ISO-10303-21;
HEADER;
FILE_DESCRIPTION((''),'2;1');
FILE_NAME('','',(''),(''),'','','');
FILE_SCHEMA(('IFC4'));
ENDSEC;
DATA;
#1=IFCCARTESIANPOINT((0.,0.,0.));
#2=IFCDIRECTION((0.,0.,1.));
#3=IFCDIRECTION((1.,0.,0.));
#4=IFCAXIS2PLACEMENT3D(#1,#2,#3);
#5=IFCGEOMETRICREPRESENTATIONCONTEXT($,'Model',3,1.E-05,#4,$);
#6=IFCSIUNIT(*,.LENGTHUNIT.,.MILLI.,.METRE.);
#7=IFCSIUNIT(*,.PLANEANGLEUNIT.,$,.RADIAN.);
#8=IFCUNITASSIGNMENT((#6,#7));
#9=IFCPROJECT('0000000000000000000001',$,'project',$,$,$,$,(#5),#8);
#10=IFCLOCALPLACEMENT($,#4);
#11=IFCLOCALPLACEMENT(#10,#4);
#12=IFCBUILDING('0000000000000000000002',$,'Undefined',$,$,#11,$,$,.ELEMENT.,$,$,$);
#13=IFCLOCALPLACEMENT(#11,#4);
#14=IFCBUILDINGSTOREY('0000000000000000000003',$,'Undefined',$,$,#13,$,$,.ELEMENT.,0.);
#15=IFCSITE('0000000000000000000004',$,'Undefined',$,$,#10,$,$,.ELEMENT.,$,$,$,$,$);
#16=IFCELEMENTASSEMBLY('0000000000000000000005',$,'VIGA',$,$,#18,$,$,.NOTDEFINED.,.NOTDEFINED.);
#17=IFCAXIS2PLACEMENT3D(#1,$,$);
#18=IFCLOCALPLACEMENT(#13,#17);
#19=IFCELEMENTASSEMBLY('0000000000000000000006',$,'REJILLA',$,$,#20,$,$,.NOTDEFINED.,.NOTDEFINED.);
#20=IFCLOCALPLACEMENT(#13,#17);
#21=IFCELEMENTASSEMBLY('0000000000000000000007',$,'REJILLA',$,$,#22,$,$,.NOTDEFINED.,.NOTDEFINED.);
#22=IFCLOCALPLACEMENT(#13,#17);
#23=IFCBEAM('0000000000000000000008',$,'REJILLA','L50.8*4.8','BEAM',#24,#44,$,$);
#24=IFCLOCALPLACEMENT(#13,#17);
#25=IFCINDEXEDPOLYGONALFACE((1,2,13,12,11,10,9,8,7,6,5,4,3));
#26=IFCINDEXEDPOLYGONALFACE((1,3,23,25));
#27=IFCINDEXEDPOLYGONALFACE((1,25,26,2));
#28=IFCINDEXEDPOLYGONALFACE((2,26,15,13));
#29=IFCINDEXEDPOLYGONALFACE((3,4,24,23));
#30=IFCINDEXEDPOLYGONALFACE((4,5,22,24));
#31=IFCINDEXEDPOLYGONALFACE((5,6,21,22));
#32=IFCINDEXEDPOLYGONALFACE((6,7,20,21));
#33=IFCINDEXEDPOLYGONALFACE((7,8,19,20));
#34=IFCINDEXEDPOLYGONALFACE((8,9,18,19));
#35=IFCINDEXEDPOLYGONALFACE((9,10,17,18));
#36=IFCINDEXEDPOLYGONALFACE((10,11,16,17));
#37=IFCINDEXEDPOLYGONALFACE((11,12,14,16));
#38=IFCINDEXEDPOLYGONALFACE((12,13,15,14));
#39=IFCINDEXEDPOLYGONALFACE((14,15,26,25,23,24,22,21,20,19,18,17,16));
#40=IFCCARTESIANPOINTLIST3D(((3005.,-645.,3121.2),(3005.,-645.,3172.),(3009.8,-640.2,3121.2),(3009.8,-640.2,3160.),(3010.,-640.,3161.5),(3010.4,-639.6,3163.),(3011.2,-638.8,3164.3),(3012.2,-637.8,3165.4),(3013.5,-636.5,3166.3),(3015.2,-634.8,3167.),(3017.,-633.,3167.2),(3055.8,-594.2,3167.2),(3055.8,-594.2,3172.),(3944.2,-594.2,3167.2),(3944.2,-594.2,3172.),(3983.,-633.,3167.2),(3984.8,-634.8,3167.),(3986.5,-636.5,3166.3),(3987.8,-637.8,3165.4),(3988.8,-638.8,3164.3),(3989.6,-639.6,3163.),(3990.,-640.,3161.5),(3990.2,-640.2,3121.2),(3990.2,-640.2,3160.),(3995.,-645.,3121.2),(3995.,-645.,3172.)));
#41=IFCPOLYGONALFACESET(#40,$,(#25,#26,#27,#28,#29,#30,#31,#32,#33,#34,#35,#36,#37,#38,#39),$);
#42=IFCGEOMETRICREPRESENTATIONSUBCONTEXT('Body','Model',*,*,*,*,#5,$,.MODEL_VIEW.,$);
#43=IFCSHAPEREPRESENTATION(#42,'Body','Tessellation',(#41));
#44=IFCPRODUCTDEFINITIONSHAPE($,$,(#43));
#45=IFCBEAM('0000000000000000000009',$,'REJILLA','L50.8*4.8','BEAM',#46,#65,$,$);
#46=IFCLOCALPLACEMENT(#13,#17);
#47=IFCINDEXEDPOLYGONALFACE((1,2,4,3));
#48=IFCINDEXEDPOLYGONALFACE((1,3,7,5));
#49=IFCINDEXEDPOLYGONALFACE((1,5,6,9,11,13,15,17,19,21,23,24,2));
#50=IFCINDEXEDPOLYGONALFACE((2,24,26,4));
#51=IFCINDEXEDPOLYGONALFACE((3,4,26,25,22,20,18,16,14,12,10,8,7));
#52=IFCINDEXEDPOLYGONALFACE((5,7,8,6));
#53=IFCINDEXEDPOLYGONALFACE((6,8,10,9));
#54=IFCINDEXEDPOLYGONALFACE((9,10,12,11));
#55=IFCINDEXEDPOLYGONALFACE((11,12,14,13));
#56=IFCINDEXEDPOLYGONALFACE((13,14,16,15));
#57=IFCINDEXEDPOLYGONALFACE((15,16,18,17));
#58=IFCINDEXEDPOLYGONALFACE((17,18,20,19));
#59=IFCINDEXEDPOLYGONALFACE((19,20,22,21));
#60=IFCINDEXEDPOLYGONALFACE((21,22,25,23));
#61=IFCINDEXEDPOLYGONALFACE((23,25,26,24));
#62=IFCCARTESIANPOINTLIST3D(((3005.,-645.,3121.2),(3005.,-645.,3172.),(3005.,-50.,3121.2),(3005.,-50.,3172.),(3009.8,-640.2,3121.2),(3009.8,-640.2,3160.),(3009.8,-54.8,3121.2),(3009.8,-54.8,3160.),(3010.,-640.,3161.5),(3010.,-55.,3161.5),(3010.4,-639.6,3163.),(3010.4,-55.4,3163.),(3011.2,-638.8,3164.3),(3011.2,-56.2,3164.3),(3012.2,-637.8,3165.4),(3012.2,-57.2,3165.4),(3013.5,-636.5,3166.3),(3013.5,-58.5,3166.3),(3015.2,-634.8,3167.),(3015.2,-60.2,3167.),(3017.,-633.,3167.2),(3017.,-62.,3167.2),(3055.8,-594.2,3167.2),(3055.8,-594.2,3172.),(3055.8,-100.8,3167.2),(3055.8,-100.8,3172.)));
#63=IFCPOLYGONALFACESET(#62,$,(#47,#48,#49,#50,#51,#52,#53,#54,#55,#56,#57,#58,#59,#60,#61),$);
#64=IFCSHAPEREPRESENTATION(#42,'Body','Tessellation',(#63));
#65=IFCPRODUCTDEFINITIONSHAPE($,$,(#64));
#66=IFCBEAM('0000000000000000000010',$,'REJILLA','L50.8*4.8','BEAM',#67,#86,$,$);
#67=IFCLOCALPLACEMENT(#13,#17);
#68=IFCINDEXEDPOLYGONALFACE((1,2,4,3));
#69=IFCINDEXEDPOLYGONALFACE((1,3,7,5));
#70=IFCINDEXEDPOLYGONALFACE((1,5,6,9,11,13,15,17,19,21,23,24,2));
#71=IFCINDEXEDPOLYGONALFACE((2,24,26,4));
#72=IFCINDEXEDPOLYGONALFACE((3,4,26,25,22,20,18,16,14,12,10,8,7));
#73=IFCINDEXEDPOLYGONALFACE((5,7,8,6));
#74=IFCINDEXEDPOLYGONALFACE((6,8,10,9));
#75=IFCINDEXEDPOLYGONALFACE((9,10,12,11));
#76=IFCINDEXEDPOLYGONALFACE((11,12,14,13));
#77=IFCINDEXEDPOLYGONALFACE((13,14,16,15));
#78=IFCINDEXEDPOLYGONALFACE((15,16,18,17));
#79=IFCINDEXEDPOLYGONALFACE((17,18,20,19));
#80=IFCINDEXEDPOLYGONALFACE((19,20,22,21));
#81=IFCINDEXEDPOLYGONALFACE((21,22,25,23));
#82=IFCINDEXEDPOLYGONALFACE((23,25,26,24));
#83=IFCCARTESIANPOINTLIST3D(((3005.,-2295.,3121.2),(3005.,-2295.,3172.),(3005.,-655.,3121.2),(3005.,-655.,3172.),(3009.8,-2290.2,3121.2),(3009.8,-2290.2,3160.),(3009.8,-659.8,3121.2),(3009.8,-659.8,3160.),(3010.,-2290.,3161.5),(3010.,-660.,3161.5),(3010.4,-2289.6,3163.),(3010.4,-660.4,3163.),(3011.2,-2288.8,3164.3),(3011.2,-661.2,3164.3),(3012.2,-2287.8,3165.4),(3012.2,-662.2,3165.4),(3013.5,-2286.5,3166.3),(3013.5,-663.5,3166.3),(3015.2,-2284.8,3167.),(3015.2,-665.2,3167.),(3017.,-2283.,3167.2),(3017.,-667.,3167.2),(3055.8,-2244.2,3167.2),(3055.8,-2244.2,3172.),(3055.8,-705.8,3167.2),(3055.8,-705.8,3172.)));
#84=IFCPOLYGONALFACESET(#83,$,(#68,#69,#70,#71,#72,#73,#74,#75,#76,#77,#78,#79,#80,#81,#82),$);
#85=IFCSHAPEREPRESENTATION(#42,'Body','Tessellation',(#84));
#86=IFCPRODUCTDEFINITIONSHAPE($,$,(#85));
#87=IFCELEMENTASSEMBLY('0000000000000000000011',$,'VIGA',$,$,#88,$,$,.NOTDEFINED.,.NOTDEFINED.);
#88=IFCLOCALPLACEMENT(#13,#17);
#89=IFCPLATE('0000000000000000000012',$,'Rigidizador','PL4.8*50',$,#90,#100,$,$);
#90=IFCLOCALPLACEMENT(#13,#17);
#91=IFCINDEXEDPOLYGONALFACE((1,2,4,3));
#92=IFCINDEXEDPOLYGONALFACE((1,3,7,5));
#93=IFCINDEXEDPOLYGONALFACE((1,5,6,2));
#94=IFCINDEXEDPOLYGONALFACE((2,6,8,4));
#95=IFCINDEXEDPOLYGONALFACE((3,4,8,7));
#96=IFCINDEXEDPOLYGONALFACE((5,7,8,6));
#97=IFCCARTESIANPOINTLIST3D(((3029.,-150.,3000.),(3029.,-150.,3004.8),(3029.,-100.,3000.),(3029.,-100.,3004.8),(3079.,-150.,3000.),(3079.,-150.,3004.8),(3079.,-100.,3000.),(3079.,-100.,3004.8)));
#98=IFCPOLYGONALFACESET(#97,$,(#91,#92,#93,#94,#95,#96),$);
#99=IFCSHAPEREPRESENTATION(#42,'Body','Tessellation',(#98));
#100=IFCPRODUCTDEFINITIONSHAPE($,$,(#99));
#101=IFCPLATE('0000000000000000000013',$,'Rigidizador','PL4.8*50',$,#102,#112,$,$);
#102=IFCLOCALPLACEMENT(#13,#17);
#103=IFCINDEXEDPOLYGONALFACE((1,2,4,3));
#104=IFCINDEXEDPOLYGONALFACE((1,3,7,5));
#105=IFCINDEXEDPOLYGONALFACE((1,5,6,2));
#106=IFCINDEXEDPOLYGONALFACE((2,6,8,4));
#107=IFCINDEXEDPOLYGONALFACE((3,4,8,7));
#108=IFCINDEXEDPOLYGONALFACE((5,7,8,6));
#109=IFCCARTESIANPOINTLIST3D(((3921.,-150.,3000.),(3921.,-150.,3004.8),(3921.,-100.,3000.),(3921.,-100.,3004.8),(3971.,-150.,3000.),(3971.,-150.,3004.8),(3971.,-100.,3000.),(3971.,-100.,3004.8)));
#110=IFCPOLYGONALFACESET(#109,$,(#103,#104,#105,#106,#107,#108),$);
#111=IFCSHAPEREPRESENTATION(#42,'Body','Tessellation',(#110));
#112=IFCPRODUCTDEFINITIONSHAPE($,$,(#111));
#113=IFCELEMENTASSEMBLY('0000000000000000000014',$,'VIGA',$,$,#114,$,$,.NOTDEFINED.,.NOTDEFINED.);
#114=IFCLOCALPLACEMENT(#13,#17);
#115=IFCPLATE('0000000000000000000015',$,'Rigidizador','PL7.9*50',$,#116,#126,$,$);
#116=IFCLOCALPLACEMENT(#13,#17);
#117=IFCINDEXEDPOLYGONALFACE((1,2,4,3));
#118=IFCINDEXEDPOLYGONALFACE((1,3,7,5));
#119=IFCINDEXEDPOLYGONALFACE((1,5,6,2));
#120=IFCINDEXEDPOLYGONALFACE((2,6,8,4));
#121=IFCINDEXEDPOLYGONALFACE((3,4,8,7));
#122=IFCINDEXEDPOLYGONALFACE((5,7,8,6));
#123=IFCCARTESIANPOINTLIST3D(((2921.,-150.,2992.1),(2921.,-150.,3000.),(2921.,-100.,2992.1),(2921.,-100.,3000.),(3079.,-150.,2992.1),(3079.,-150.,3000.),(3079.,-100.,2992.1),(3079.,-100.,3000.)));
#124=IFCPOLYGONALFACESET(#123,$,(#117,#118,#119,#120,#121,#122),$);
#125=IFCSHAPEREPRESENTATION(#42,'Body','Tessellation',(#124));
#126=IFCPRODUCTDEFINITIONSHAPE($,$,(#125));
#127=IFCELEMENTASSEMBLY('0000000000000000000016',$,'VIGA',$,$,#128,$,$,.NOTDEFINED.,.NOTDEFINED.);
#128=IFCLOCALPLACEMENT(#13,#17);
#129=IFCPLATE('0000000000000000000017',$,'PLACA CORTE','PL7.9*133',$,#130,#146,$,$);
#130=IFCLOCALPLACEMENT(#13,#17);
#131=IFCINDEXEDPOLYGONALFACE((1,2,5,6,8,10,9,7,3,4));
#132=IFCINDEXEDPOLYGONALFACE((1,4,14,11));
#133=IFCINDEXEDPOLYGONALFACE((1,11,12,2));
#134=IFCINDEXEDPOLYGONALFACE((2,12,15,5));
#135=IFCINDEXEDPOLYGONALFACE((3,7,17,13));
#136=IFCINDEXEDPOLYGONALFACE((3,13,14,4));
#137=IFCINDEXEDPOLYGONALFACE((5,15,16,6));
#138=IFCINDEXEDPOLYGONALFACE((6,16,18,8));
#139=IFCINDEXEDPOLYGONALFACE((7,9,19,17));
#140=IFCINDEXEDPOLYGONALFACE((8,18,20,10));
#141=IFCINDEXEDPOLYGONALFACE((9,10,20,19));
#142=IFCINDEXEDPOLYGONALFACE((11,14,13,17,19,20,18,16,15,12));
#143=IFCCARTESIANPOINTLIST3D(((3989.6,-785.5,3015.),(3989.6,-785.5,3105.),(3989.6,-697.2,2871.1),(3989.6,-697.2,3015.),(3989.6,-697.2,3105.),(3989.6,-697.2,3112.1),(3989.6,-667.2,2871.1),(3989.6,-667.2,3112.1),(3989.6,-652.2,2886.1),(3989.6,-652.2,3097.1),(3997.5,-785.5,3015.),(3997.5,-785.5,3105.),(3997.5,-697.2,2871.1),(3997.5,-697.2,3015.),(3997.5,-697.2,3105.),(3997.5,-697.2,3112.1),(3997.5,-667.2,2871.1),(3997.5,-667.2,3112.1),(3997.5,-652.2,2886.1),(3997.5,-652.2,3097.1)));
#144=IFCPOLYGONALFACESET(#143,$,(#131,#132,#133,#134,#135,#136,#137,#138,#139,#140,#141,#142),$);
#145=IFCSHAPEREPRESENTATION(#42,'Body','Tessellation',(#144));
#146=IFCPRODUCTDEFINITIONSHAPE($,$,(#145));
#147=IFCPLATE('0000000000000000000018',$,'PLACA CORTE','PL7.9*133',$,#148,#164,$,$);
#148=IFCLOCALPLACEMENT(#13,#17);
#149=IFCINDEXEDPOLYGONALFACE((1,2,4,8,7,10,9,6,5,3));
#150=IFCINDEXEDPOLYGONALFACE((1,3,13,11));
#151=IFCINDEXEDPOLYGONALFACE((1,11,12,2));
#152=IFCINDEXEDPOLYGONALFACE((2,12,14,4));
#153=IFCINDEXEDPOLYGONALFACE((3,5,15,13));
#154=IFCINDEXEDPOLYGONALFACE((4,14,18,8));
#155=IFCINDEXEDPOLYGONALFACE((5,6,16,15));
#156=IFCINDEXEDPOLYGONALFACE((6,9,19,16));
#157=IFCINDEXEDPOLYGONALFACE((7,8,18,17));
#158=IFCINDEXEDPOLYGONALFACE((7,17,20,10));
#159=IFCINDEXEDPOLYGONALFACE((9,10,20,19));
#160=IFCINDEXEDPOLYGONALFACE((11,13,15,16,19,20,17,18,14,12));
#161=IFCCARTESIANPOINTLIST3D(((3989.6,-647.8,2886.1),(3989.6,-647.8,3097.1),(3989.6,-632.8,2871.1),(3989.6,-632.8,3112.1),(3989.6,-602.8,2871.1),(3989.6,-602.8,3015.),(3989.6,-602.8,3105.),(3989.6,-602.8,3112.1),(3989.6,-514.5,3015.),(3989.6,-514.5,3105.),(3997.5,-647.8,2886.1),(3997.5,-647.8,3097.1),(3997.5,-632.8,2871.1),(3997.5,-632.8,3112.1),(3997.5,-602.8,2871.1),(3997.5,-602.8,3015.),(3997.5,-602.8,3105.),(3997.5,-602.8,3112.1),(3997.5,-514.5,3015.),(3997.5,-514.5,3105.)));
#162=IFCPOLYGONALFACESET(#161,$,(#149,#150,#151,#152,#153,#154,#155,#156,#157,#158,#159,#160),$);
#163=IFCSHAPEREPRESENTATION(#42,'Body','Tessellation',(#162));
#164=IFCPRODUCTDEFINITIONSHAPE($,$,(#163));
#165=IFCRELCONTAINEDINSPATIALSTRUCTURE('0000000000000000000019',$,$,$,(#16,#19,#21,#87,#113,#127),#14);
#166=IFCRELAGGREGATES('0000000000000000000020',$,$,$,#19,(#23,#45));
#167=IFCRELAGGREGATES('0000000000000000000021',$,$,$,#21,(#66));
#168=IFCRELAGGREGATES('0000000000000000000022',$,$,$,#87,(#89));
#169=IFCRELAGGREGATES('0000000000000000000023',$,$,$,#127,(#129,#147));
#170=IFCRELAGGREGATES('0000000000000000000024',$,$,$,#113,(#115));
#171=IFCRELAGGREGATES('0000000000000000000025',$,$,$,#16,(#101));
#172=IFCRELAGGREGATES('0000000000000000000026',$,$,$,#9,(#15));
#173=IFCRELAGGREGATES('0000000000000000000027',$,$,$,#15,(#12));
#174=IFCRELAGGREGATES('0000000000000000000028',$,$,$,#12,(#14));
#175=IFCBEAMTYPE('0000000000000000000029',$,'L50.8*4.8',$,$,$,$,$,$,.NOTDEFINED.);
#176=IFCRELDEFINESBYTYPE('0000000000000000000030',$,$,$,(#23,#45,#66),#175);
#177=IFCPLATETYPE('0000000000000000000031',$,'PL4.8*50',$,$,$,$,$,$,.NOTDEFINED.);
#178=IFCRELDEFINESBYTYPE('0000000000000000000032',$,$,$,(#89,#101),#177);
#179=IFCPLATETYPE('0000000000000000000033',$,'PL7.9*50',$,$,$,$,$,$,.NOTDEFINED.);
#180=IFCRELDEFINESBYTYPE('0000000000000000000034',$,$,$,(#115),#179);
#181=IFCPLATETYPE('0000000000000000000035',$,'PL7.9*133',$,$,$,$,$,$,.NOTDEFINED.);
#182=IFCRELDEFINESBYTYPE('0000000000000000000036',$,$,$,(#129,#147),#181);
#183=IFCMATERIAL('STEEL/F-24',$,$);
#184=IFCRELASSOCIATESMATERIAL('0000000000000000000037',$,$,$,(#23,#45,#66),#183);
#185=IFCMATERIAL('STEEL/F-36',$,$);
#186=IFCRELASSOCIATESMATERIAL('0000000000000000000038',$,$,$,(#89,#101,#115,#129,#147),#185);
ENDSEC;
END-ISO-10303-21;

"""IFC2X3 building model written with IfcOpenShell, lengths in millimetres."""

from ifc_helpers import new_model, si_unit, frame, origin_with_axes, origin_2d_with_axis, place, context, subcontext, project, spatial, polyline, l_section, outline, extrude, clip, halfspace, material, type_object, element, aggregate, save


model = new_model("IFC2X3")

# Units and contexts
model_context = context("Model", 3, precision=1e-05, world=origin_with_axes())
body_context = subcontext(model_context, "Body", "Model", "MODEL_VIEW")
ifc_project = project(units=[si_unit("LENGTHUNIT", "METRE", prefix="MILLI"), si_unit("PLANEANGLEUNIT", "RADIAN")], contexts=[model_context])

# Site, building, storey
site_placement = place(None, origin_with_axes())
site = spatial("IfcSite", under=ifc_project, at=site_placement, Name="Undefined", CompositionType="ELEMENT")
building_placement = place(site_placement, origin_with_axes())
building = spatial("IfcBuilding", under=site, at=building_placement, Name="Undefined", CompositionType="ELEMENT")
storey_placement = place(building_placement, origin_with_axes())
storey = spatial("IfcBuildingStorey", under=building, at=storey_placement, Name="Undefined", CompositionType="ELEMENT", Elevation=0.0)

# Element assembly
assembly_1_placement = place(storey_placement, origin_with_axes())
assembly_1 = element("IfcElementAssembly", 1, at=assembly_1_placement, inside=storey, Name="VIGA", AssemblyPlace="NOTDEFINED", PredefinedType="NOTDEFINED")
ifc_material_1 = material(Name="STEEL/F-36")

# Element assemblies
assembly_2_placement = place(storey_placement, origin_with_axes())
assembly_2 = element("IfcElementAssembly", 2, at=assembly_2_placement, inside=storey, Name="REJILLA", AssemblyPlace="NOTDEFINED", PredefinedType="NOTDEFINED")
ifc_material_2 = material(Name="STEEL/F-24")
assembly_3_placement = place(storey_placement, origin_with_axes())
assembly_3 = element("IfcElementAssembly", 3, at=assembly_3_placement, inside=storey, Name="REJILLA", AssemblyPlace="NOTDEFINED", PredefinedType="NOTDEFINED")

# Shared definitions
beam_type_1 = type_object("IfcBeamType", Name="L50.8*4.8", PredefinedType="NOTDEFINED")

# Beams
beam_1_placement = place(assembly_2_placement, frame((3005.0, -619.6, 3146.6), z_axis=(0.0, 0.0, -1.0), x_axis=(1.0, 0.0, 0.0)))
beam_1 = element("IfcBeam", 4, at=beam_1_placement, type_object=beam_type_1, material=ifc_material_2, Name="REJILLA", Description="L50.8*4.8", ObjectType="BEAM", context=body_context, shape_type="Clipping", body=[
    clip(clip(extrude(l_section(Depth=50.8, Width=50.8, Thickness=4.8, FilletRadius=7.2, at=origin_2d_with_axis()), frame((1015.9, 0.0, 0.0), z_axis=(-1.0, 0.0, 0.0), x_axis=(0.0, -1.0, 0.0)), (0.0, 0.0, 1.0), 1041.8), halfspace(frame((939.2, -25.4, 0.0), z_axis=(-0.707107, 0.707107, 0.0), x_axis=(0.0, 0.0, -1.0)), True)), halfspace(frame((50.8, -25.4, 0.0), z_axis=(-0.707107, -0.707107, 0.0), x_axis=(0.0, 0.0, -1.0)), False)),
])
beam_2_placement = place(assembly_2_placement, frame((3030.4, 0.0, 3146.6), z_axis=(0.0, 0.0, -1.0), x_axis=(0.0, -1.0, 0.0)))
beam_2 = element("IfcBeam", 5, at=beam_2_placement, type_object=beam_type_1, material=ifc_material_2, Name="REJILLA", Description="L50.8*4.8", ObjectType="BEAM", context=body_context, shape_type="Clipping", body=[
    clip(clip(extrude(l_section(Depth=50.8, Width=50.8, Thickness=4.8, FilletRadius=7.2, at=origin_2d_with_axis()), frame((670.9, 0.0, 0.0), z_axis=(-1.0, 0.0, 0.0), x_axis=(0.0, -1.0, 0.0)), (0.0, 0.0, 1.0), 670.9), halfspace(frame((594.2, -25.4, 0.0), z_axis=(-0.707107, 0.707107, 0.0), x_axis=(0.0, 0.0, -1.0)), True)), halfspace(frame((100.8, -25.4, 0.0), z_axis=(-0.707107, -0.707107, 0.0), x_axis=(0.0, 0.0, -1.0)), False)),
])
beam_3_placement = place(assembly_3_placement, frame((3030.4, -655.0, 3146.6), z_axis=(0.0, 0.0, -1.0), x_axis=(0.0, -1.0, 0.0)))
beam_3 = element("IfcBeam", 6, at=beam_3_placement, type_object=beam_type_1, material=ifc_material_2, Name="REJILLA", Description="L50.8*4.8", ObjectType="BEAM", context=body_context, shape_type="Clipping", body=[
    clip(clip(extrude(l_section(Depth=50.8, Width=50.8, Thickness=4.8, FilletRadius=7.2, at=origin_2d_with_axis()), frame((1665.9, 0.0, 0.0), z_axis=(-1.0, 0.0, 0.0), x_axis=(0.0, -1.0, 0.0)), (0.0, 0.0, 1.0), 1691.8), halfspace(frame((1589.2, -25.4, 0.0), z_axis=(-0.707107, 0.707107, 0.0), x_axis=(0.0, 0.0, -1.0)), True)), halfspace(frame((50.8, -25.4, 0.0), z_axis=(-0.707107, -0.707107, 0.0), x_axis=(0.0, 0.0, -1.0)), False)),
])
aggregate(assembly_2, [beam_1, beam_2])
aggregate(assembly_3, [beam_3])

# Element assembly, plate
assembly_4_placement = place(storey_placement, origin_with_axes())
assembly_4 = element("IfcElementAssembly", 7, at=assembly_4_placement, inside=storey, Name="VIGA", AssemblyPlace="NOTDEFINED", PredefinedType="NOTDEFINED")
plate_type_1 = type_object("IfcPlateType", Name="PL4.8*50", PredefinedType="NOTDEFINED")
plate_1_placement = place(assembly_4_placement, frame((3079.0, -100.0, 3002.4), z_axis=(0.0, 0.0, 1.0), x_axis=(-1.0, 0.000001, 0.0)))
plate_1 = element("IfcPlate", 8, at=plate_1_placement, type_object=plate_type_1, material=ifc_material_1, Name="Rigidizador", Description="PL4.8*50", context=body_context, shape_type="SweptSolid", body=[
    extrude(outline(polyline([(0.0, 0.0), (50.0, 0.0), (50.0, 50.0), (0.0, 50.0), (0.0, 0.0)])), frame((0.0, 0.0, -2.4), z_axis=(0.0, 0.0, 1.0), x_axis=(1.0, 0.0, 0.0)), (0.0, 0.0, 1.0), 4.8),
])
aggregate(assembly_4, [plate_1])

# Plate
plate_2_placement = place(assembly_1_placement, frame((3971.0, -100.0, 3002.4), z_axis=(0.0, 0.0, 1.0), x_axis=(-1.0, 0.000001, 0.0)))
plate_2 = element("IfcPlate", 9, at=plate_2_placement, type_object=plate_type_1, material=ifc_material_1, Name="Rigidizador", Description="PL4.8*50", context=body_context, shape_type="SweptSolid", body=[
    extrude(outline(polyline([(0.0, 0.0), (50.0, 0.0), (50.0, 50.0), (0.0, 50.0), (0.0, 0.0)])), frame((0.0, 0.0, -2.4), z_axis=(0.0, 0.0, 1.0), x_axis=(1.0, 0.0, 0.0)), (0.0, 0.0, 1.0), 4.8),
])

# Element assembly, plate
assembly_5_placement = place(storey_placement, origin_with_axes())
assembly_5 = element("IfcElementAssembly", 10, at=assembly_5_placement, inside=storey, Name="VIGA", AssemblyPlace="NOTDEFINED", PredefinedType="NOTDEFINED")
plate_type_2 = type_object("IfcPlateType", Name="PL7.9*50", PredefinedType="NOTDEFINED")
plate_3_placement = place(assembly_5_placement, frame((3079.0, -100.0, 2996.0), z_axis=(0.0, 0.0, 1.0), x_axis=(-1.0, 0.0, 0.0)))
plate_3 = element("IfcPlate", 11, at=plate_3_placement, type_object=plate_type_2, material=ifc_material_1, Name="Rigidizador", Description="PL7.9*50", context=body_context, shape_type="SweptSolid", body=[
    extrude(outline(polyline([(0.0, 0.0), (158.0, 0.0), (158.0, 50.0), (0.0, 50.0), (0.0, 0.0)])), frame((0.0, 0.0, -4.0), z_axis=(0.0, 0.0, 1.0), x_axis=(1.0, 0.0, 0.0)), (0.0, 0.0, 1.0), 7.9),
])

# Element assembly, plates
assembly_6_placement = place(storey_placement, origin_with_axes())
assembly_6 = element("IfcElementAssembly", 12, at=assembly_6_placement, inside=storey, Name="VIGA", AssemblyPlace="NOTDEFINED", PredefinedType="NOTDEFINED")
plate_type_3 = type_object("IfcPlateType", Name="PL7.9*133", PredefinedType="NOTDEFINED")
plate_4_placement = place(assembly_6_placement, frame((3993.5, -652.2, 2871.1), z_axis=(-1.0, 0.0, 0.0), x_axis=(0.0, -1.0, 0.0)))
plate_4 = element("IfcPlate", 13, at=plate_4_placement, type_object=plate_type_3, material=ifc_material_1, Name="PLACA CORTE", Description="PL7.9*133", context=body_context, shape_type="SweptSolid", body=[
    extrude(outline(polyline([(0.0, 15.0), (15.0, 0.0), (45.0, 0.0), (45.0, 143.9), (133.2, 143.9), (133.2, 233.9), (45.0, 233.9), (45.0, 241.0), (15.0, 241.0), (0.0, 226.0), (0.0, 15.0)])), frame((0.0, 0.0, -4.0), z_axis=(0.0, 0.0, 1.0), x_axis=(1.0, 0.0, 0.0)), (0.0, 0.0, 1.0), 7.9),
])
plate_5_placement = place(assembly_6_placement, frame((3993.5, -647.8, 2871.1), z_axis=(1.0, 0.0, 0.0), x_axis=(0.0, 1.0, 0.0)))
plate_5 = element("IfcPlate", 14, at=plate_5_placement, type_object=plate_type_3, material=ifc_material_1, Name="PLACA CORTE", Description="PL7.9*133", context=body_context, shape_type="SweptSolid", body=[
    extrude(outline(polyline([(0.0, 15.0), (15.0, 0.0), (45.0, 0.0), (45.0, 143.9), (133.2, 143.9), (133.2, 233.9), (45.0, 233.9), (45.0, 241.0), (15.0, 241.0), (0.0, 226.0), (0.0, 15.0)])), frame((0.0, 0.0, -4.0), z_axis=(0.0, 0.0, 1.0), x_axis=(1.0, 0.0, 0.0)), (0.0, 0.0, 1.0), 7.9),
])
aggregate(assembly_6, [plate_4, plate_5])

aggregate(assembly_5, [plate_3])
aggregate(assembly_1, [plate_2])

save(model, "model.ifc")
